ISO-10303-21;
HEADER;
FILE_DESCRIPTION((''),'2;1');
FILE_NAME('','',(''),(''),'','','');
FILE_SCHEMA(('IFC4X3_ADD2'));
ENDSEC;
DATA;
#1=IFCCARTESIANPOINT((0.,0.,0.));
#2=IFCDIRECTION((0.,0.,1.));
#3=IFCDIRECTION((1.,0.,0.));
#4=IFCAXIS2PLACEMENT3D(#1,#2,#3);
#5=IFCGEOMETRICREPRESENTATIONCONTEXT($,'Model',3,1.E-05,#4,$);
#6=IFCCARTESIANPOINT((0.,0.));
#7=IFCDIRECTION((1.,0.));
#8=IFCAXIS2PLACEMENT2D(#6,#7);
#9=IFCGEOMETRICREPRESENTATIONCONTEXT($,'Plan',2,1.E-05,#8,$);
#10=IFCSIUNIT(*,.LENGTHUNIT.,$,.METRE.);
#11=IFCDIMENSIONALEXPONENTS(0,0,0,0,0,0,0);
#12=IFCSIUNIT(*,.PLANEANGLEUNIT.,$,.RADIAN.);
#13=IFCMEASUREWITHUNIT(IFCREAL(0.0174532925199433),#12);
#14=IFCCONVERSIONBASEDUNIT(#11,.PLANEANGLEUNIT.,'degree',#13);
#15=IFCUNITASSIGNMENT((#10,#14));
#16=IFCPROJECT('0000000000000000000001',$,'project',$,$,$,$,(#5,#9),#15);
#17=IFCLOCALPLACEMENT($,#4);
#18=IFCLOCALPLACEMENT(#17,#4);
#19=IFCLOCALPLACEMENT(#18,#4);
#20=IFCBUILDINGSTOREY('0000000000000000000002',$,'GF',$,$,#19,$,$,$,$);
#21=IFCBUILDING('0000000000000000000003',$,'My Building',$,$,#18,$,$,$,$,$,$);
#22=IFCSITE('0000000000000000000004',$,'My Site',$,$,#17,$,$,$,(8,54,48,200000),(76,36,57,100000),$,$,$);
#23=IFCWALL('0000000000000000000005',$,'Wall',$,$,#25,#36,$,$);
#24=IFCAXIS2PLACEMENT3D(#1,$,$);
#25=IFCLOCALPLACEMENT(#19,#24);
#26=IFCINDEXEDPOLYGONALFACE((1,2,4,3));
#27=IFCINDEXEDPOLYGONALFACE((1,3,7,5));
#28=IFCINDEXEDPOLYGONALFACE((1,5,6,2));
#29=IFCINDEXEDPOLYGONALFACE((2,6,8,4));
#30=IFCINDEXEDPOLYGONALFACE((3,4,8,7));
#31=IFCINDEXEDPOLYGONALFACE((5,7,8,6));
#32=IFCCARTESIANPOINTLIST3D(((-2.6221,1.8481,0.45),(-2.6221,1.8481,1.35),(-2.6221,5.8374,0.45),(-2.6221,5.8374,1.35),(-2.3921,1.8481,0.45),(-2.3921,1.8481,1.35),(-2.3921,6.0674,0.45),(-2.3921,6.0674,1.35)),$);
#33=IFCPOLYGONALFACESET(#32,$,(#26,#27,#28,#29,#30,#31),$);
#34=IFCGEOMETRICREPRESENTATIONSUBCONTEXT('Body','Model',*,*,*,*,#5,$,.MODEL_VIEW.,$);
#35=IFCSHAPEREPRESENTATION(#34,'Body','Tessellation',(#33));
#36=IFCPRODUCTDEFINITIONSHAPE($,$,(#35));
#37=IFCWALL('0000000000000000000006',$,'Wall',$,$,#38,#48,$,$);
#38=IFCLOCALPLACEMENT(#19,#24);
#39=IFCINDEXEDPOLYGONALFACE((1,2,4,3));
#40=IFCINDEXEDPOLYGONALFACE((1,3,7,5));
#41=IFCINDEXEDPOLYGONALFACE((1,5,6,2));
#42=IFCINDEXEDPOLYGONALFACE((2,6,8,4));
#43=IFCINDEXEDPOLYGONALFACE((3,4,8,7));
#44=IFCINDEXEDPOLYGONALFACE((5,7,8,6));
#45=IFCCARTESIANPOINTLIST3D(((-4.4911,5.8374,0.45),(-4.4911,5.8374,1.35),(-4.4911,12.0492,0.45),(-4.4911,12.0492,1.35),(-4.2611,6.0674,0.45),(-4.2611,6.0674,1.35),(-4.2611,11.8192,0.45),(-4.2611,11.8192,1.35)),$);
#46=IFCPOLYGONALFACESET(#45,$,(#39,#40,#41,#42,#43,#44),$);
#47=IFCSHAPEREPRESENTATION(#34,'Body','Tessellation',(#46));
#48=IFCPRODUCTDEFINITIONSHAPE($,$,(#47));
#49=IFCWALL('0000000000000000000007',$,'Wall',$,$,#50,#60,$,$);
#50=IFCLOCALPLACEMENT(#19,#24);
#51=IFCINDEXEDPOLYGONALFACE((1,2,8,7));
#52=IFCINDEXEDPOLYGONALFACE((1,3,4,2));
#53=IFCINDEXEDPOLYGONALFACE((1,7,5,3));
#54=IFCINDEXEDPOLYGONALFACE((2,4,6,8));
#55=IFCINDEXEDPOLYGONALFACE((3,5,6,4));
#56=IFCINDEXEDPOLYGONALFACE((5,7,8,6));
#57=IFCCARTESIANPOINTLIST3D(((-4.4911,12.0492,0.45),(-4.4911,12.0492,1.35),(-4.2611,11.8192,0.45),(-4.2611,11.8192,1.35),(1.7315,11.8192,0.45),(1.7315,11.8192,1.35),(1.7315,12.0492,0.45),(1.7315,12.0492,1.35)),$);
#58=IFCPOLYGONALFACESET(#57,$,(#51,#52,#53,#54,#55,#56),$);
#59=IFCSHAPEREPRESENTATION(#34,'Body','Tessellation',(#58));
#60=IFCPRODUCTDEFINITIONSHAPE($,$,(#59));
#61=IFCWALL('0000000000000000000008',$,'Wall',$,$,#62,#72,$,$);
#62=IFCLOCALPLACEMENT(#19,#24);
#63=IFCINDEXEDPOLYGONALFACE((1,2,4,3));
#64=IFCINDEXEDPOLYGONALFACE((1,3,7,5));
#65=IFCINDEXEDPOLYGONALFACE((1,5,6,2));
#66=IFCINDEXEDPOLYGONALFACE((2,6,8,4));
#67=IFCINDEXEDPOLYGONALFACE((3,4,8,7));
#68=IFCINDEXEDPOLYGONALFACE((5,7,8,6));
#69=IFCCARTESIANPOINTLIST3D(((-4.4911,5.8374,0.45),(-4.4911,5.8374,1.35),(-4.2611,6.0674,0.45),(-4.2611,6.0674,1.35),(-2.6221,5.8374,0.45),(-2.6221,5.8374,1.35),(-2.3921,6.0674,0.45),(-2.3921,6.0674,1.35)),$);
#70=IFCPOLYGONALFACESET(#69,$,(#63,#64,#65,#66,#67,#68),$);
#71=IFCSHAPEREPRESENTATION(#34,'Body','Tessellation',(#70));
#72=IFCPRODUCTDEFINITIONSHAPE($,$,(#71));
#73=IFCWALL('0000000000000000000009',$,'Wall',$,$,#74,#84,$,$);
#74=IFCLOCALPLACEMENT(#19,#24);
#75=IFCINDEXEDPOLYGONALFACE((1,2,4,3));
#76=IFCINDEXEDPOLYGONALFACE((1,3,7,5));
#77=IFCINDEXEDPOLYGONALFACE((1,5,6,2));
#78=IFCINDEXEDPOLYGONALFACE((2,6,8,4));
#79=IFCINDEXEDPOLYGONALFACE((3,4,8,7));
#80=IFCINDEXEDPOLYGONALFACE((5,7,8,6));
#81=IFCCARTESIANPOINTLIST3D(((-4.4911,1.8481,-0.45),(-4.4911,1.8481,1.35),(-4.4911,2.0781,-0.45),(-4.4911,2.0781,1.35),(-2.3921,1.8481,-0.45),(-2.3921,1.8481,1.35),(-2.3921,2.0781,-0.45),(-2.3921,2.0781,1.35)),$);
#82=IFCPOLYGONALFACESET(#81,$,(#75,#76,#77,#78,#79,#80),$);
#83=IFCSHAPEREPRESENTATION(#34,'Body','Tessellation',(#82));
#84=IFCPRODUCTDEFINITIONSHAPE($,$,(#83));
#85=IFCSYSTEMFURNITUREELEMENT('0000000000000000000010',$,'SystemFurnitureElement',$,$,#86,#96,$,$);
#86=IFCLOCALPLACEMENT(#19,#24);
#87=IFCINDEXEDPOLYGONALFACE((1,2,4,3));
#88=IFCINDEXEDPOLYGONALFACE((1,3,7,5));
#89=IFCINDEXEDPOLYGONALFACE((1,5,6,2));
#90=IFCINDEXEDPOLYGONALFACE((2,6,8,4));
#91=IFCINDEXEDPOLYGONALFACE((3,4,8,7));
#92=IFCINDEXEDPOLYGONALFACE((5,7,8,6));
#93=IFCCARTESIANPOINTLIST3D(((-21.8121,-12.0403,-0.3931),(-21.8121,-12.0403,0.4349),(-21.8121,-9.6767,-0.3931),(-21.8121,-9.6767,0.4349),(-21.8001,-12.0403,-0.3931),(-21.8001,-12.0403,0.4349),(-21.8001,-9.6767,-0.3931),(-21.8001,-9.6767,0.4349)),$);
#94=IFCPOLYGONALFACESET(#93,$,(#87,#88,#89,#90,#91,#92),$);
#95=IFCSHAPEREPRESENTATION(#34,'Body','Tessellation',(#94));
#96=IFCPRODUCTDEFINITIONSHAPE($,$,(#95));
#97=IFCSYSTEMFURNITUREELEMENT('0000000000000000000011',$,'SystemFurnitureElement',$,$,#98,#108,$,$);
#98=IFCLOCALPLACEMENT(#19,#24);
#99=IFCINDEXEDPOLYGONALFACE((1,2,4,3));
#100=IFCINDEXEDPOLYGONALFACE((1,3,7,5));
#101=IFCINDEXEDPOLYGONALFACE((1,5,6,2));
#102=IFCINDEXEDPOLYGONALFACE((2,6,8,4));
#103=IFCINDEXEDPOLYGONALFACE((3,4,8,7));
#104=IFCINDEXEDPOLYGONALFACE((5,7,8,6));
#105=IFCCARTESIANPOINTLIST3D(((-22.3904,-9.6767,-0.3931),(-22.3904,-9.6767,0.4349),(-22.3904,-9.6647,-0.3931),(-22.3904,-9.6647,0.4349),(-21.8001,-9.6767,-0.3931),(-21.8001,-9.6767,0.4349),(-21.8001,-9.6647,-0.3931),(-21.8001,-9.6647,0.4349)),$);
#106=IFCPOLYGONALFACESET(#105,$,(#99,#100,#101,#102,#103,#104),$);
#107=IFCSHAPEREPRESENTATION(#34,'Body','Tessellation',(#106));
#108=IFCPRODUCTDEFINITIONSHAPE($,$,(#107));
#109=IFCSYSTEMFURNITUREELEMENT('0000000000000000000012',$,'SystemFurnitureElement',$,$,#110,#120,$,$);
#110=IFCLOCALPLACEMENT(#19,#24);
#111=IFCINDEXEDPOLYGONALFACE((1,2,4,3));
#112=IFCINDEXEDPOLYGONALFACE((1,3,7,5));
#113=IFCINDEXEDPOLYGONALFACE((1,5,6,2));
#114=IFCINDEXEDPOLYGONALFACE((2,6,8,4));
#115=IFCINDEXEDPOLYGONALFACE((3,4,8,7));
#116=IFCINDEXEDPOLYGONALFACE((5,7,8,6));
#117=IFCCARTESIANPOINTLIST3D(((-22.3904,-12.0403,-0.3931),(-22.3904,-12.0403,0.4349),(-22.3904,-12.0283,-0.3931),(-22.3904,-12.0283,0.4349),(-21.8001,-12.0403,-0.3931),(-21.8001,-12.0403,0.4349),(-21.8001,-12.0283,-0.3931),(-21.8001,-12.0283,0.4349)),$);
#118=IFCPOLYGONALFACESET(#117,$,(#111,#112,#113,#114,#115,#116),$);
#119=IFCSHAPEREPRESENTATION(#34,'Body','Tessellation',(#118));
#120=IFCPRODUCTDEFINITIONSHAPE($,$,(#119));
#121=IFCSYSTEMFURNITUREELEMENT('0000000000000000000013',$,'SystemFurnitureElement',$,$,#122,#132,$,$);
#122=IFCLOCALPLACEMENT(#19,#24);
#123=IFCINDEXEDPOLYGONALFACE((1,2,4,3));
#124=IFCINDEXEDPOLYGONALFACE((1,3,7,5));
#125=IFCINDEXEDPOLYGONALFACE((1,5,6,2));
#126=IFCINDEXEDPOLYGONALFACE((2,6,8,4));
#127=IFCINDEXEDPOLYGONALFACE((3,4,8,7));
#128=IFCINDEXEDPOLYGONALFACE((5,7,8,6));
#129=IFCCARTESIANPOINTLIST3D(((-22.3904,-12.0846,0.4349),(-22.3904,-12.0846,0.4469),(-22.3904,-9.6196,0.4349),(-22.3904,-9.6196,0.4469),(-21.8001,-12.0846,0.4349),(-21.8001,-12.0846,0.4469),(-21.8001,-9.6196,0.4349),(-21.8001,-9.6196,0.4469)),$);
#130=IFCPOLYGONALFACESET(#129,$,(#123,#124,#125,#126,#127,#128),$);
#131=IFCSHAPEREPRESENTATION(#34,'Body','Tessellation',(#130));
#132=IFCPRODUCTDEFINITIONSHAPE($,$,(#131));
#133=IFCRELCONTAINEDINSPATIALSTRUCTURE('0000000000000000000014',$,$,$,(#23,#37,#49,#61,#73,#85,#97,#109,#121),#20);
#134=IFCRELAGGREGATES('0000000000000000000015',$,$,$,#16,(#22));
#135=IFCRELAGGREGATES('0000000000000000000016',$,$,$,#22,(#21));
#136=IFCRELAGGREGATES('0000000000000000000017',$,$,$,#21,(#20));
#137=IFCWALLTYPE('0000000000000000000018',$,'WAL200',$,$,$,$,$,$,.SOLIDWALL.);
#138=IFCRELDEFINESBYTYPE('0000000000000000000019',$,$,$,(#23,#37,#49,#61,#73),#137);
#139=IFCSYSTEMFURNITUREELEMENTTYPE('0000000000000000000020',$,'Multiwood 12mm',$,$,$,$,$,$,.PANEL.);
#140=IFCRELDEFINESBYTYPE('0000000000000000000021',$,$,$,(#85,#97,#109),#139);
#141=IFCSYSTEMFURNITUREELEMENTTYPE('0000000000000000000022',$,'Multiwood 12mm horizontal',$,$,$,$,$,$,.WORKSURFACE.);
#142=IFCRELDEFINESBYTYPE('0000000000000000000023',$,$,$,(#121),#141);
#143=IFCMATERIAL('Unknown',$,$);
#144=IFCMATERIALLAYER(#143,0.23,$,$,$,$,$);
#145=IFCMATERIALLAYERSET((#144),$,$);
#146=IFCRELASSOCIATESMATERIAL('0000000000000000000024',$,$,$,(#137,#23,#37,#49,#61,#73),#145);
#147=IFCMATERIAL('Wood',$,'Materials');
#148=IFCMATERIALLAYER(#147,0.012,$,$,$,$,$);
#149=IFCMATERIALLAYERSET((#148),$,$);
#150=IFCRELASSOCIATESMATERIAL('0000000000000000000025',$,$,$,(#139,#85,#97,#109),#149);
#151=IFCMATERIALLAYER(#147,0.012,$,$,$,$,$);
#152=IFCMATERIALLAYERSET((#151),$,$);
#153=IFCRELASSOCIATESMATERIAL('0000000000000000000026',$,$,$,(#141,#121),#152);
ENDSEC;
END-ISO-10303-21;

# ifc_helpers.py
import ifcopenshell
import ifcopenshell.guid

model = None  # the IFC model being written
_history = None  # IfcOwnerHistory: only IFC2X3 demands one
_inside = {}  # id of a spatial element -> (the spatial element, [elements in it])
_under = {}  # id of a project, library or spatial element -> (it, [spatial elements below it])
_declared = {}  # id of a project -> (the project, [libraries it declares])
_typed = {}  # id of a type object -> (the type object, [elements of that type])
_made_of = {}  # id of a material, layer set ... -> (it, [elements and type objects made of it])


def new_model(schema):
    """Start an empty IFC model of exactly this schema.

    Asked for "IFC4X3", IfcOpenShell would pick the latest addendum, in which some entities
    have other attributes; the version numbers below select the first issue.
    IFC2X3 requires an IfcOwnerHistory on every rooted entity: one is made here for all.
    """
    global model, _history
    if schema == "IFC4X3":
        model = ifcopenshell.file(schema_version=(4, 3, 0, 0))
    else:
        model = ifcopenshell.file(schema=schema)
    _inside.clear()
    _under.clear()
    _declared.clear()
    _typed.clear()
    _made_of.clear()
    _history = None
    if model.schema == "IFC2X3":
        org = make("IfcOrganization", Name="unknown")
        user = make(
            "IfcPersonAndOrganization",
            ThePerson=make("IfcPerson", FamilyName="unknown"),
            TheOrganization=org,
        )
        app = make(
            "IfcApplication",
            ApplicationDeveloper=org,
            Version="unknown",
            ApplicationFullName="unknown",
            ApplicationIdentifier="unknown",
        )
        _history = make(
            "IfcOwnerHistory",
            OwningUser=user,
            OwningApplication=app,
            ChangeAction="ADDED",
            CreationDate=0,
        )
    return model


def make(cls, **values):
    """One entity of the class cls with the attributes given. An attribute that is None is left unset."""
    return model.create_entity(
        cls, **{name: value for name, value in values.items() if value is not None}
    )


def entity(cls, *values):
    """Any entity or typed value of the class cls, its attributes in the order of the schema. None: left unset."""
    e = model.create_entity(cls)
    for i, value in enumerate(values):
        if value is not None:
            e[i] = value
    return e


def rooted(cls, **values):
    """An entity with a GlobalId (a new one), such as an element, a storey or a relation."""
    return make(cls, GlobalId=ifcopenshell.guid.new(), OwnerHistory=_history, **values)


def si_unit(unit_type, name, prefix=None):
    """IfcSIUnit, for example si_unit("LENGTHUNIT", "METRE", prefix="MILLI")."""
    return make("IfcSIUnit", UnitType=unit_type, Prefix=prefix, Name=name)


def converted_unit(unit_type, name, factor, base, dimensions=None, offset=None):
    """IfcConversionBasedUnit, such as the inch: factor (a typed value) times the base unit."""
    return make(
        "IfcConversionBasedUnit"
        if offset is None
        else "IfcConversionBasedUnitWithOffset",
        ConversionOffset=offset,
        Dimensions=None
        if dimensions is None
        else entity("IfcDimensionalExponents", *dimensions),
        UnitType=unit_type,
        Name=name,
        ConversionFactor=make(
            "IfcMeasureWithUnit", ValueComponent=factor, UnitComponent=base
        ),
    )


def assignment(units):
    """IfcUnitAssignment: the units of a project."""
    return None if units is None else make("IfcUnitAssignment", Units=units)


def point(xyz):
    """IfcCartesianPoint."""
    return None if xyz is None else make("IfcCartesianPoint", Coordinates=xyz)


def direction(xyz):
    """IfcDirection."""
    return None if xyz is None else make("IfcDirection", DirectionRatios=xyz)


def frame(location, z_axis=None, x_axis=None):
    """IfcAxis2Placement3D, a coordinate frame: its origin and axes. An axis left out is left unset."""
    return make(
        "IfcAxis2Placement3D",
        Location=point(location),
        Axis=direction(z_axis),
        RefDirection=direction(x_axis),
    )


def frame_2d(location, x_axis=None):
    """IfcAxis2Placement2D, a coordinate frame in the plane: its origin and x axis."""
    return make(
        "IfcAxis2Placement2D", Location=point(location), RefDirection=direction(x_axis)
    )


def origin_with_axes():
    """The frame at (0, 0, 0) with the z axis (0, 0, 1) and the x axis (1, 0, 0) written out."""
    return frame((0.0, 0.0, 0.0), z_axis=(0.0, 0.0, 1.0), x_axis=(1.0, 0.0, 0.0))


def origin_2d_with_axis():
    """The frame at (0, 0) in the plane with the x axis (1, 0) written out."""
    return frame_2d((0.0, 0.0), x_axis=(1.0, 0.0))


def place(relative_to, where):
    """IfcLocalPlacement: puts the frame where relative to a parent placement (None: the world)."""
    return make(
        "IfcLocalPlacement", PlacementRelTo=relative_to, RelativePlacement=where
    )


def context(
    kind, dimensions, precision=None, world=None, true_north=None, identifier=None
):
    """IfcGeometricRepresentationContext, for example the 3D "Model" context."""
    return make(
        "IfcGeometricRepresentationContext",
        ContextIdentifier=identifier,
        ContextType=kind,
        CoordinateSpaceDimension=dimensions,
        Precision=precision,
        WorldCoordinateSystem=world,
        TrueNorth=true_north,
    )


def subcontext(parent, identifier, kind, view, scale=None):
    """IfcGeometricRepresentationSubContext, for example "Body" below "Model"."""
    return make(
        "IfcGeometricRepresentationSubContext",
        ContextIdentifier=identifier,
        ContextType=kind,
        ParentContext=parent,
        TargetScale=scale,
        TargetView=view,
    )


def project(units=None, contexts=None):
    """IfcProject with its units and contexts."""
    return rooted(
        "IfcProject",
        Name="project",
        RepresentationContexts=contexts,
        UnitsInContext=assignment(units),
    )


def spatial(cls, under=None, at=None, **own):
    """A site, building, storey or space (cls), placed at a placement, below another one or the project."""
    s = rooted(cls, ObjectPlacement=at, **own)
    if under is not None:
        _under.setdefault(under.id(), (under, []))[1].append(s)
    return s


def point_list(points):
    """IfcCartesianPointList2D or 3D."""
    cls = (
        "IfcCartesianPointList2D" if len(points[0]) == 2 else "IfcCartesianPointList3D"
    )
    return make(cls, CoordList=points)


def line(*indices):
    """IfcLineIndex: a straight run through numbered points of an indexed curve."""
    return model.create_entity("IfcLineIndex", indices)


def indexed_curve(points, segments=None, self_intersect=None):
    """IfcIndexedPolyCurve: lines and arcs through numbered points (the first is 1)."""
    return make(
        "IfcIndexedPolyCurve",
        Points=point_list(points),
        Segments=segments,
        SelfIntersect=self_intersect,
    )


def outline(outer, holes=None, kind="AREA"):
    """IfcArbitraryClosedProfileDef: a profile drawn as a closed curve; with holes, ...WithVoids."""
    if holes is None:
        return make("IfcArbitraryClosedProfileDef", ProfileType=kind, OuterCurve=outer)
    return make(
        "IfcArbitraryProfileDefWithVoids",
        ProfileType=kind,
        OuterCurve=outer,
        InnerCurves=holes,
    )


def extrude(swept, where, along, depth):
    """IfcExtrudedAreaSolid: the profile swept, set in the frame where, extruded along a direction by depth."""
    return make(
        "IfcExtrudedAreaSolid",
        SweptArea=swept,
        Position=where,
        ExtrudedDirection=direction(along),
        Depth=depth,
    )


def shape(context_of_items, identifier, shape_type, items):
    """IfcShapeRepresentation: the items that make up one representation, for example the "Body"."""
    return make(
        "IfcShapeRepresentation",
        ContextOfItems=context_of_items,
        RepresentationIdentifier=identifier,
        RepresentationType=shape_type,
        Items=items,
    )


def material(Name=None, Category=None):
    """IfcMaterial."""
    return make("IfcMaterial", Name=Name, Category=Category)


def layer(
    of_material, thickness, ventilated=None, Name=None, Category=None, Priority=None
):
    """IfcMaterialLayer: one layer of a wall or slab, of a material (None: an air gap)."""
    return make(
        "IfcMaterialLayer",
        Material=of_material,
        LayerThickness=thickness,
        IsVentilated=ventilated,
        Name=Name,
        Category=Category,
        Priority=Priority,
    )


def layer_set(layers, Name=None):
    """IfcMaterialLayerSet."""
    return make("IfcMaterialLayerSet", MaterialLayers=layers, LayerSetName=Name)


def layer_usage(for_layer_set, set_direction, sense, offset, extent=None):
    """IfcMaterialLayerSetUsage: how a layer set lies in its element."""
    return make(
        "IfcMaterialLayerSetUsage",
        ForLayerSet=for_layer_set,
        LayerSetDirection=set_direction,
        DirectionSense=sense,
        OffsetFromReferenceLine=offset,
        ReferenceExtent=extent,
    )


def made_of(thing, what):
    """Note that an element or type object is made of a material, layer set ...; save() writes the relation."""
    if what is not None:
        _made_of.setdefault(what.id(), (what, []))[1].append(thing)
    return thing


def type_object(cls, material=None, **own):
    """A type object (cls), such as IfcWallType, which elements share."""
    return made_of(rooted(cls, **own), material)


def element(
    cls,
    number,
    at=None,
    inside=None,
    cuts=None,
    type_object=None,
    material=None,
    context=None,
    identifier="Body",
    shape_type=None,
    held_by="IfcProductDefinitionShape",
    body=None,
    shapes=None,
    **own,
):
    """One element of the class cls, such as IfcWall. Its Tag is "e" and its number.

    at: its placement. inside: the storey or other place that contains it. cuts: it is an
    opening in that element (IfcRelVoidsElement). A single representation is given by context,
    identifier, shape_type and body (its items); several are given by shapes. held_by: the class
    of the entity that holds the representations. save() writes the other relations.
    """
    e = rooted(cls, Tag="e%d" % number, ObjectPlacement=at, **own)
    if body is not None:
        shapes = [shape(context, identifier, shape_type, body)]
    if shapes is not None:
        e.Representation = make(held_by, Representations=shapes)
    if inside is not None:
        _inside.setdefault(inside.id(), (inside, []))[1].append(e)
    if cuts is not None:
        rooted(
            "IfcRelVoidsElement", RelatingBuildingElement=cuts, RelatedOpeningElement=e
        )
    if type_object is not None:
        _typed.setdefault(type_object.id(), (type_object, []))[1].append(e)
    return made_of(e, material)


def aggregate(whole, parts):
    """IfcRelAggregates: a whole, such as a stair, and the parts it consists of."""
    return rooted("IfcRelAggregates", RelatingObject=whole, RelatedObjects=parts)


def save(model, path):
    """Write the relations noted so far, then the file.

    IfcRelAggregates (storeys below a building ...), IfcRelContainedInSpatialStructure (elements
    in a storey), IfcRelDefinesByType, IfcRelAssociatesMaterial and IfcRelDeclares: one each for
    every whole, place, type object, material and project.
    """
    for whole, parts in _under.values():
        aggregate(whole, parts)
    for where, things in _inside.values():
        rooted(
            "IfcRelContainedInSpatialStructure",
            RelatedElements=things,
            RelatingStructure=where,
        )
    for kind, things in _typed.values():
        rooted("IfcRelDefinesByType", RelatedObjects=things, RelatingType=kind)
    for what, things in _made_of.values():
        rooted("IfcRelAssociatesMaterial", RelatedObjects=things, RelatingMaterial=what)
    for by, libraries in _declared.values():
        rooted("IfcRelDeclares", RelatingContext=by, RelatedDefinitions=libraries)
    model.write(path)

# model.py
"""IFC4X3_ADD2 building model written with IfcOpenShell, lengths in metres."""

from ifc_helpers import new_model, entity, si_unit, converted_unit, frame, origin_with_axes, origin_2d_with_axis, place, context, subcontext, project, spatial, line, indexed_curve, outline, extrude, material, layer, layer_set, layer_usage, type_object, element, save


model = new_model("IFC4X3_ADD2")

# Units and contexts
model_context = context("Model", 3, precision=1e-05, world=origin_with_axes())
plan_context = context("Plan", 2, precision=1e-05, world=origin_2d_with_axis())
body_context = subcontext(model_context, "Body", "Model", "MODEL_VIEW")
ifc_project = project(units=[si_unit("LENGTHUNIT", "METRE"), converted_unit("PLANEANGLEUNIT", "degree", entity("IfcReal", 0.0174532925199433), si_unit("PLANEANGLEUNIT", "RADIAN"), dimensions=[0, 0, 0, 0, 0, 0, 0])], contexts=[model_context, plan_context])

# Site, building, storey
site_placement = place(None, origin_with_axes())
site = spatial("IfcSite", under=ifc_project, at=site_placement, Name="My Site", RefLatitude=(8, 54, 48, 200000), RefLongitude=(76, 36, 57, 100000))
building_placement = place(site_placement, origin_with_axes())
building = spatial("IfcBuilding", under=site, at=building_placement, Name="My Building")
storey_placement = place(building_placement, origin_with_axes())
storey = spatial("IfcBuildingStorey", under=building, at=storey_placement, Name="GF")

# Walls
ifc_material_1 = material(Name="Unknown")
ifc_layer_1 = layer(ifc_material_1, 0.23)
ifc_layer_set_1 = layer_set([ifc_layer_1])
wall_type = type_object("IfcWallType", Name="WAL200", PredefinedType="SOLIDWALL", material=ifc_layer_set_1)
ifc_layer_usage_1 = layer_usage(ifc_layer_set_1, "AXIS2", "POSITIVE", 0.0)
wall_1_placement = place(storey_placement, frame((-2.3921, 1.8481, 0.45), z_axis=(0.0, 0.0, 1.0), x_axis=(0.000001, 1.0, 0.0)))
element("IfcWall", 1, at=wall_1_placement, inside=storey, type_object=wall_type, material=ifc_layer_usage_1, Name="Wall", context=body_context, shape_type="SweptSolid", body=[
    extrude(outline(indexed_curve([(0.0, 0.0), (0.0, 0.23), (3.9893, 0.23), (4.2193, 0.0)], segments=[line(1, 2, 3, 4, 1)])), origin_with_axes(), (0.0, 0.0, 1.0), 0.9),
])
ifc_layer_usage_2 = layer_usage(ifc_layer_set_1, "AXIS2", "POSITIVE", 0.0)
wall_2_placement = place(storey_placement, frame((-4.2611, 5.8374, 0.45), z_axis=(0.0, 0.0, 1.0), x_axis=(0.000001, 1.0, 0.0)))
element("IfcWall", 2, at=wall_2_placement, inside=storey, type_object=wall_type, material=ifc_layer_usage_2, Name="Wall", context=body_context, shape_type="SweptSolid", body=[
    extrude(outline(indexed_curve([(0.23, 0.0), (0.0, 0.23), (6.2118, 0.23), (5.9818, 0.0)], segments=[line(1, 2, 3, 4, 1)])), origin_with_axes(), (0.0, 0.0, 1.0), 0.9),
])
ifc_layer_usage_3 = layer_usage(ifc_layer_set_1, "AXIS2", "POSITIVE", 0.0)
wall_3_placement = place(storey_placement, frame((1.7315, 12.0492, 0.45), z_axis=(0.0, 0.0, 1.0), x_axis=(-1.0, 0.000001, 0.0)))
element("IfcWall", 3, at=wall_3_placement, inside=storey, type_object=wall_type, material=ifc_layer_usage_3, Name="Wall", context=body_context, shape_type="SweptSolid", body=[
    extrude(outline(indexed_curve([(0.0, 0.0), (0.0, 0.23), (5.9926, 0.23), (6.2226, 0.0)], segments=[line(1, 2, 3, 4, 1)])), origin_with_axes(), (0.0, 0.0, 1.0), 0.9),
])
ifc_layer_usage_4 = layer_usage(ifc_layer_set_1, "AXIS2", "NEGATIVE", 0.0)
wall_4_placement = place(storey_placement, frame((-2.3921, 5.8374, 0.45), z_axis=(0.0, 0.0, 1.0), x_axis=(-1.0, 0.000001, 0.0)))
element("IfcWall", 4, at=wall_4_placement, inside=storey, type_object=wall_type, material=ifc_layer_usage_4, Name="Wall", context=body_context, shape_type="SweptSolid", body=[
    extrude(outline(indexed_curve([(0.0, -0.23), (0.23, 0.0), (2.099, 0.0), (1.869, -0.23)], segments=[line(1, 2, 3, 4, 1)])), origin_with_axes(), (0.0, 0.0, 1.0), 0.9),
])
ifc_layer_usage_5 = layer_usage(ifc_layer_set_1, "AXIS2", "NEGATIVE", 0.0)
wall_5_placement = place(storey_placement, frame((-2.3921, 1.8481, -0.45), z_axis=(0.0, 0.0, 1.0), x_axis=(-1.0, 0.000001, 0.0)))
element("IfcWall", 5, at=wall_5_placement, inside=storey, type_object=wall_type, material=ifc_layer_usage_5, Name="Wall", context=body_context, shape_type="SweptSolid", body=[
    extrude(outline(indexed_curve([(0.0, -0.23), (0.0, 0.0), (2.099, 0.0), (2.099, -0.23)], segments=[line(1, 2, 3, 4, 1)])), origin_with_axes(), (0.0, 0.0, 1.0), 1.8),
])

# System furniture elements
ifc_material_2 = material(Name="Wood", Category="Materials")
ifc_layer_2 = layer(ifc_material_2, 0.012)
ifc_layer_set_2 = layer_set([ifc_layer_2])
ifc_layer_usage_6 = layer_usage(ifc_layer_set_2, "AXIS2", "POSITIVE", 0.0)
system_furniture_element_type_1 = type_object("IfcSystemFurnitureElementType", Name="Multiwood 12mm", PredefinedType="PANEL", material=ifc_layer_set_2)
system_furniture_element_1_placement = place(storey_placement, frame((-21.8121, -9.6767, -0.3931), z_axis=(0.0, 0.0, 1.0), x_axis=(-0.000001, -1.0, 0.0)))
element("IfcSystemFurnitureElement", 6, at=system_furniture_element_1_placement, inside=storey, type_object=system_furniture_element_type_1, material=ifc_layer_usage_6, Name="SystemFurnitureElement", context=body_context, shape_type="SweptSolid", body=[
    extrude(outline(indexed_curve([(0.0, 0.0), (0.0, 0.012), (2.3635, 0.012), (2.3635, 0.0)], segments=[line(1, 2, 3, 4, 1)])), origin_with_axes(), (0.0, 0.0, 1.0), 0.828),
])
ifc_layer_usage_7 = layer_usage(ifc_layer_set_2, "AXIS2", "POSITIVE", 0.0)
system_furniture_element_2_placement = place(storey_placement, frame((-22.3904, -9.6767, -0.3931), z_axis=(0.0, 0.0, 1.0), x_axis=(1.0, 0.0, 0.0)))
element("IfcSystemFurnitureElement", 7, at=system_furniture_element_2_placement, inside=storey, type_object=system_furniture_element_type_1, material=ifc_layer_usage_7, Name="SystemFurnitureElement", context=body_context, shape_type="SweptSolid", body=[
    extrude(outline(indexed_curve([(0.0, 0.0), (0.0, 0.012), (0.5903, 0.012), (0.5903, 0.0)], segments=[line(1, 2, 3, 4, 1)])), origin_with_axes(), (0.0, 0.0, 1.0), 0.828),
])
ifc_layer_usage_8 = layer_usage(ifc_layer_set_2, "AXIS2", "POSITIVE", 0.0)
system_furniture_element_3_placement = place(storey_placement, frame((-22.3904, -12.0403, -0.3931), z_axis=(0.0, 0.0, 1.0), x_axis=(1.0, 0.0, 0.0)))
element("IfcSystemFurnitureElement", 8, at=system_furniture_element_3_placement, inside=storey, type_object=system_furniture_element_type_1, material=ifc_layer_usage_8, Name="SystemFurnitureElement", context=body_context, shape_type="SweptSolid", body=[
    extrude(outline(indexed_curve([(0.0, 0.0), (0.0, 0.012), (0.5903, 0.012), (0.5903, 0.0)], segments=[line(1, 2, 3, 4, 1)])), origin_with_axes(), (0.0, 0.0, 1.0), 0.828),
])
ifc_layer_3 = layer(ifc_material_2, 0.012)
ifc_layer_set_3 = layer_set([ifc_layer_3])
ifc_layer_usage_9 = layer_usage(ifc_layer_set_3, "AXIS3", "POSITIVE", -0.012)
system_furniture_element_type_2 = type_object("IfcSystemFurnitureElementType", Name="Multiwood 12mm horizontal", PredefinedType="WORKSURFACE", material=ifc_layer_set_3)
system_furniture_element_4_placement = place(storey_placement, frame((-21.8001, -9.6196, 0.4469), z_axis=(0.0, 0.0, 1.0), x_axis=(1.0, 0.0, 0.0)))
element("IfcSystemFurnitureElement", 9, at=system_furniture_element_4_placement, inside=storey, type_object=system_furniture_element_type_2, material=ifc_layer_usage_9, Name="SystemFurnitureElement", context=body_context, shape_type="SweptSolid", body=[
    extrude(outline(indexed_curve([(0.0, -2.4649), (-0.5903, -2.4649), (-0.5903, 0.0), (0.0, 0.0), (0.0, -2.4649)])), frame((0.0, 0.0, -0.012), z_axis=(0.0, 0.0, 1.0), x_axis=(1.0, 0.0, 0.0)), (0.0, 0.0, 1.0), 0.012),
])

save(model, "model.ifc")
